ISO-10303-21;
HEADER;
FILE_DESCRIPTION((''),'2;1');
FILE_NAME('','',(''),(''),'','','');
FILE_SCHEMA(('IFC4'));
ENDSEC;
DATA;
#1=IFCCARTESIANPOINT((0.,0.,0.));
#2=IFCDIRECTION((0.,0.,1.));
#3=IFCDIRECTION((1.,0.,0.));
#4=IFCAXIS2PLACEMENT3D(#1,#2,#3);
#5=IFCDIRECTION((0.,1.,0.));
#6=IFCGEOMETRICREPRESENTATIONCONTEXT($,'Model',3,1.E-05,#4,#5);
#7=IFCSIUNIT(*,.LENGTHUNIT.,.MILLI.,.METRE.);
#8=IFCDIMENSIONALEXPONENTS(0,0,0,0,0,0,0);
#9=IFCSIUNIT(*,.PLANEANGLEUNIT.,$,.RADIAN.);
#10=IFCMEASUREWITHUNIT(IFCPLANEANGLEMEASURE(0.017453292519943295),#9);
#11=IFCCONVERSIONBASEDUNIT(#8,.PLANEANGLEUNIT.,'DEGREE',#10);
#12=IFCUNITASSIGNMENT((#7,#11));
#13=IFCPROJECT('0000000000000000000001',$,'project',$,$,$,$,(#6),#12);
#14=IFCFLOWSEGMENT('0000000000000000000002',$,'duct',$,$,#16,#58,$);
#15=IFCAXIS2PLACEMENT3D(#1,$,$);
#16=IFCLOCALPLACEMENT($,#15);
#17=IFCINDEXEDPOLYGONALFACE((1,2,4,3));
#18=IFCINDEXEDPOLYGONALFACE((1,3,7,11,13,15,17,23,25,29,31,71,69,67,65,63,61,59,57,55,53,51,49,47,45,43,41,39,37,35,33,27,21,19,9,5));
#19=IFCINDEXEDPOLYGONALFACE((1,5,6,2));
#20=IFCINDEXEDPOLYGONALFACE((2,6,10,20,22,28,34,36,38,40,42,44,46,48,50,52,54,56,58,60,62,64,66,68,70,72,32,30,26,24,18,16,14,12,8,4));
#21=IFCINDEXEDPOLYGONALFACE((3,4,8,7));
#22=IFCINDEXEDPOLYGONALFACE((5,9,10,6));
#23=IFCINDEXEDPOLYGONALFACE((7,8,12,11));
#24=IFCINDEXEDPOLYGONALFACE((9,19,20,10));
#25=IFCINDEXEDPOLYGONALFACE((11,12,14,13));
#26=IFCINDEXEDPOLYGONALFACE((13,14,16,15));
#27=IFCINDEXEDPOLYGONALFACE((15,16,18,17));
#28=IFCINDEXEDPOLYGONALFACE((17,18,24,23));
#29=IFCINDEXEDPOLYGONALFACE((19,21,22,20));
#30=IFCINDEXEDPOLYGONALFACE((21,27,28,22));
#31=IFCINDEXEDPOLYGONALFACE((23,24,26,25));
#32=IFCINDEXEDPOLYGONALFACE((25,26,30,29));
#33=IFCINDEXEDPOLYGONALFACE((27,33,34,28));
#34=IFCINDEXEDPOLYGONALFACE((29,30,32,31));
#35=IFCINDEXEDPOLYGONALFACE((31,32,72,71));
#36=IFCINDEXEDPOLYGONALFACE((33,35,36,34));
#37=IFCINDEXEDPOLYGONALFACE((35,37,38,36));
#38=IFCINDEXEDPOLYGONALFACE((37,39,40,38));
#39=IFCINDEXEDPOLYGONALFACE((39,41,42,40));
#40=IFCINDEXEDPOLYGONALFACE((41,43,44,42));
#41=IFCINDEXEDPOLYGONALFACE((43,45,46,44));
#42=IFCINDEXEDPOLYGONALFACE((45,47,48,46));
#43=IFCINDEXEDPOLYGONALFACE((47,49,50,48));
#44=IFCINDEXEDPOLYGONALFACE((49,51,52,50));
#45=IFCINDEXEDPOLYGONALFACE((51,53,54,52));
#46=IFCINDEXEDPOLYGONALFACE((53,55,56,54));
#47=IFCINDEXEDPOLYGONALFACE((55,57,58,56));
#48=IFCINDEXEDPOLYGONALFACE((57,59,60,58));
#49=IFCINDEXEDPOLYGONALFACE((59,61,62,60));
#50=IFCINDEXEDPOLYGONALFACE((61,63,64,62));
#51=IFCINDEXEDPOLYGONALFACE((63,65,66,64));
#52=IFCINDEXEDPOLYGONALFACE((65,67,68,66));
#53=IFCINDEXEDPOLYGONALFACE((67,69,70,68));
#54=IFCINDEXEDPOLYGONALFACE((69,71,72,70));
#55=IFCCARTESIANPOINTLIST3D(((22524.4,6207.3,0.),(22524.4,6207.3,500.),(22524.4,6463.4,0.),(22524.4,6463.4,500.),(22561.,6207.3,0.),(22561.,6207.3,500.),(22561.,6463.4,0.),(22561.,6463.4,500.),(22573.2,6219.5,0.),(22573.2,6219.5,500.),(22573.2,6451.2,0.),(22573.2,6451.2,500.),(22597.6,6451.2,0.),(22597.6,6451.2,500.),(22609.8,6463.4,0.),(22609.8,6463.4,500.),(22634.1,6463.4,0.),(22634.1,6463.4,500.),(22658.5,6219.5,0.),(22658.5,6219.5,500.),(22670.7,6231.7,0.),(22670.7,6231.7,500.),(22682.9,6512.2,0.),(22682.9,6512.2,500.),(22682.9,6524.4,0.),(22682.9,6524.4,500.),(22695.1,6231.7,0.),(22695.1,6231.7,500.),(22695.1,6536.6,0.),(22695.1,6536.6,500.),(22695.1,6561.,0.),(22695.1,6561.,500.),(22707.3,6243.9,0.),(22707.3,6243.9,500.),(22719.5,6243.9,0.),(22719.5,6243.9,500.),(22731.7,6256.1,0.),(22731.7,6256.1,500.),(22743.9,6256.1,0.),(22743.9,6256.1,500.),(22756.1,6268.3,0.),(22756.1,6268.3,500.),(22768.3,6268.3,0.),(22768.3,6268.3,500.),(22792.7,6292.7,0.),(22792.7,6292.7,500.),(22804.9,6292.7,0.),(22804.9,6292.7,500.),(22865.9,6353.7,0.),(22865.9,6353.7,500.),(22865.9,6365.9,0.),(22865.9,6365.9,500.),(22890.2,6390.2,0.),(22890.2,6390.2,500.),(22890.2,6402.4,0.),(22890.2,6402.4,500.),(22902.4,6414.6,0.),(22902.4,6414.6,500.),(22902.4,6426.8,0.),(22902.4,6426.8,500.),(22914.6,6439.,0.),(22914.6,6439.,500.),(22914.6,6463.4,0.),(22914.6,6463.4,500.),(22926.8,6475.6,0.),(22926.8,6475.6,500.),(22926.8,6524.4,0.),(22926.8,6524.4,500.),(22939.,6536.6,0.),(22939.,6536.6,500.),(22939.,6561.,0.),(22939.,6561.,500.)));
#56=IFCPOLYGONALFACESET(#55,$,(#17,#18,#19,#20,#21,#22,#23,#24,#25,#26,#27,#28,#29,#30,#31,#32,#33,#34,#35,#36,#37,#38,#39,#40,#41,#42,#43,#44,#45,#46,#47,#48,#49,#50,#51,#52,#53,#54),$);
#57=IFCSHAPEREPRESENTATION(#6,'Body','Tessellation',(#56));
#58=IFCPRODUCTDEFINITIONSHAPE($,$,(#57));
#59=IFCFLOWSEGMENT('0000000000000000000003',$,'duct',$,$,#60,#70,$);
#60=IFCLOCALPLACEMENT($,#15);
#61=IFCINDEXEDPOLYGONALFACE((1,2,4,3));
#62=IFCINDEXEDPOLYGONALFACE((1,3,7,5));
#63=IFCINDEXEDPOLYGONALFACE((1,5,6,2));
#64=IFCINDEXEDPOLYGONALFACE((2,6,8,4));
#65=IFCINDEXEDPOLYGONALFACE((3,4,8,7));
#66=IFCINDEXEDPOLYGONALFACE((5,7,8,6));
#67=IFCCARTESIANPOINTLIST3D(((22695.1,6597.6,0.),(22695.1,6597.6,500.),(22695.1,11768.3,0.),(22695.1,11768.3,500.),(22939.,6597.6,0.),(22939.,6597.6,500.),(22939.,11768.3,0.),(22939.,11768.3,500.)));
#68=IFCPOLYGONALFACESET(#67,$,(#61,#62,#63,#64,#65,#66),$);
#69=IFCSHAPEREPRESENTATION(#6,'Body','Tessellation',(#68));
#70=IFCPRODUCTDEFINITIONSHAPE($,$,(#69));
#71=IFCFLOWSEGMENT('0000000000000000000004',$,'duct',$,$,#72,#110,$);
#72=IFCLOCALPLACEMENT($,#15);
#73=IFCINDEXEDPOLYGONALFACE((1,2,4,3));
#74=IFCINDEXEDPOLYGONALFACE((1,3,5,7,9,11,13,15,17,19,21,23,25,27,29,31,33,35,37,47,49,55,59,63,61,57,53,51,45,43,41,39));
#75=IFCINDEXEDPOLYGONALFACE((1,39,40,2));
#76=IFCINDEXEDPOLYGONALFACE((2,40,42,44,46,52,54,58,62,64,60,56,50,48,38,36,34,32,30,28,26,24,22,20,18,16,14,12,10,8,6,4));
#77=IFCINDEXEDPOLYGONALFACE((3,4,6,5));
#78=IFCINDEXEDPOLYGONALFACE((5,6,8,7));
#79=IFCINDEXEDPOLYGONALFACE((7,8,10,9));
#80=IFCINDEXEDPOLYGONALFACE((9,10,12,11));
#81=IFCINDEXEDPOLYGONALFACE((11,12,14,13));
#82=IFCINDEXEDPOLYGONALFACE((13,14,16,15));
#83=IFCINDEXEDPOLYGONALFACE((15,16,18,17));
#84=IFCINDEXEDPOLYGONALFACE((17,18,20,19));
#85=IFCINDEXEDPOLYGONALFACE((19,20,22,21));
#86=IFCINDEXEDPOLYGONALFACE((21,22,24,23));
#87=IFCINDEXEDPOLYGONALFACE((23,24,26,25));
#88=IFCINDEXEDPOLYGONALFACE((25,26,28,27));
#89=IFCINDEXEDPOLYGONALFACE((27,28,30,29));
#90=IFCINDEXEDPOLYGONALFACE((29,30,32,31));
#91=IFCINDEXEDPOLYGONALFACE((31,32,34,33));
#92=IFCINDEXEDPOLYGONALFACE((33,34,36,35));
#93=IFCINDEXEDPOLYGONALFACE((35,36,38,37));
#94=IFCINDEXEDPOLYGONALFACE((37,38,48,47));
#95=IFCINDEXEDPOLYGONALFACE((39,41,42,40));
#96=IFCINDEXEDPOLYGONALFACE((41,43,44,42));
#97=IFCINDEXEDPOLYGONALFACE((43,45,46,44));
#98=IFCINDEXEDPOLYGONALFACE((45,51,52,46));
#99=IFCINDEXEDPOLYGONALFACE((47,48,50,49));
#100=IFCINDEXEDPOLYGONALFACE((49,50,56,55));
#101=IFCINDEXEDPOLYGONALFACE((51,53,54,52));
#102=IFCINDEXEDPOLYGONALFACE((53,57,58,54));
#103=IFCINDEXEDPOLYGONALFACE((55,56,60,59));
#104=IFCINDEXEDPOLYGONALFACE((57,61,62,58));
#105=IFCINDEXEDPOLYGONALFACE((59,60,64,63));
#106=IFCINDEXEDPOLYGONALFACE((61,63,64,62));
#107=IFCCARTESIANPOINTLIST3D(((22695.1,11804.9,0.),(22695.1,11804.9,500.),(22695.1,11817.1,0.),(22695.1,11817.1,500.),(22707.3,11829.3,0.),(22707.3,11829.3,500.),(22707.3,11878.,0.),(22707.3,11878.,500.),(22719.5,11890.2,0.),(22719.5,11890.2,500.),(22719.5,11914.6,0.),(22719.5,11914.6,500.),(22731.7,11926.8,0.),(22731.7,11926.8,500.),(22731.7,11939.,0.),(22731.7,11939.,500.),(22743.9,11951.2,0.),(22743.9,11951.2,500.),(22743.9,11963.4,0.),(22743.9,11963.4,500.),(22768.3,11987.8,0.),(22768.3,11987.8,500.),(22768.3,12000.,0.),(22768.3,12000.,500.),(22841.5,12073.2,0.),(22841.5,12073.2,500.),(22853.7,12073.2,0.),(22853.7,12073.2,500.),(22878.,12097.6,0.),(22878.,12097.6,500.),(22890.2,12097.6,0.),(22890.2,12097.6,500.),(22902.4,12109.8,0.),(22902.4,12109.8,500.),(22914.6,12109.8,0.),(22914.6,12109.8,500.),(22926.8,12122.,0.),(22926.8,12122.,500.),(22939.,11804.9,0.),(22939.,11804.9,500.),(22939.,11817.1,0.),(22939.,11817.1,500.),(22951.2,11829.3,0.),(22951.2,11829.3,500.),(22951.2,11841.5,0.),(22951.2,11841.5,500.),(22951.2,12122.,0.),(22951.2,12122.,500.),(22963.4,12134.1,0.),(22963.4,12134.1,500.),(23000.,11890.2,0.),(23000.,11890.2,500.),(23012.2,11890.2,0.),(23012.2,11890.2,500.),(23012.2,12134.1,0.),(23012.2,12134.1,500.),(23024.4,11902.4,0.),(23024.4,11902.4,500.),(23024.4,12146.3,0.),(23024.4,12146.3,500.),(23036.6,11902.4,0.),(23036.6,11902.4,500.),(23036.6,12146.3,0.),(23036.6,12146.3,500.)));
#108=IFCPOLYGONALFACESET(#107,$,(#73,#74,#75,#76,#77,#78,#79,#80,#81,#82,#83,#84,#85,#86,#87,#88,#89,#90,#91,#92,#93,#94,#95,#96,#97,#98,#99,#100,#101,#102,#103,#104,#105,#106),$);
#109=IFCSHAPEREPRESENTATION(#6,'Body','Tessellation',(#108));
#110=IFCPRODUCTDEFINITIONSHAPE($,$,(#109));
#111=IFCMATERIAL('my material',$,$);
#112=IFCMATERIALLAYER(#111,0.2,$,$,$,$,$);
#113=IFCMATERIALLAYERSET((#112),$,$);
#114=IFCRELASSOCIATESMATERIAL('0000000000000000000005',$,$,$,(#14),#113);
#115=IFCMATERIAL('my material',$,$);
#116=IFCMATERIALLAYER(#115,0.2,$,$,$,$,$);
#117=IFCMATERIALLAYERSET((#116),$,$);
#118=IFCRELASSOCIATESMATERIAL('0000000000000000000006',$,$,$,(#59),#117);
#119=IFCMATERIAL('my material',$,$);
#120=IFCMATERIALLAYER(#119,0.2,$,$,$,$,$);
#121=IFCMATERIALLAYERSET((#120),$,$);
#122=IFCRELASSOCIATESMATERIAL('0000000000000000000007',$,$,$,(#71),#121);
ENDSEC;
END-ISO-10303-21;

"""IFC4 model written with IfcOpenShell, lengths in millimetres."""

from ifc_helpers import new_model, entity, si_unit, converted_unit, direction, origin_with_axes, place, context, project, polyline, outline, extrude, material, layer, layer_set, layer_usage, element, save


model = new_model("IFC4")

# Units and contexts
model_context = context("Model", 3, precision=1e-05, world=origin_with_axes(), true_north=direction((0.0, 1.0, 0.0)))
ifc_project = project(units=[si_unit("LENGTHUNIT", "METRE", prefix="MILLI"), converted_unit("PLANEANGLEUNIT", "DEGREE", entity("IfcPlaneAngleMeasure", 0.017453292519943295), si_unit("PLANEANGLEUNIT", "RADIAN"), dimensions=[0, 0, 0, 0, 0, 0, 0])], contexts=[model_context])

# Flow segments
ifc_material_1 = material(Name="my material")
ifc_layer_1 = layer(ifc_material_1, 0.2)
ifc_layer_set_1 = layer_set([ifc_layer_1])
ifc_layer_usage_1 = layer_usage(ifc_layer_set_1, "AXIS2", "POSITIVE", -0.1)
flow_segment_1_placement = place(None, origin_with_axes())
element("IfcFlowSegment", 1, at=flow_segment_1_placement, material=ifc_layer_usage_1, Name="duct", context=model_context, shape_type="SweptSolid", body=[
    extrude(outline(polyline([(22524.4, 6207.3), (22561.0, 6207.3), (22573.2, 6219.5), (22658.5, 6219.5), (22670.7, 6231.7), (22695.1, 6231.7), (22707.3, 6243.9), (22719.5, 6243.9), (22731.7, 6256.1), (22743.9, 6256.1), (22756.1, 6268.3), (22768.3, 6268.3), (22792.7, 6292.7), (22804.9, 6292.7), (22865.9, 6353.7), (22865.9, 6365.9), (22890.2, 6390.2), (22890.2, 6402.4), (22902.4, 6414.6), (22902.4, 6426.8), (22914.6, 6439.0), (22914.6, 6463.4), (22926.8, 6475.6), (22926.8, 6524.4), (22939.0, 6536.6), (22939.0, 6561.0), (22695.1, 6561.0), (22695.1, 6536.6), (22682.9, 6524.4), (22682.9, 6512.2), (22634.1, 6463.4), (22609.8, 6463.4), (22597.6, 6451.2), (22573.2, 6451.2), (22561.0, 6463.4), (22524.4, 6463.4), (22524.4, 6207.3)])), origin_with_axes(), (0.0, 0.0, 1.0), 500.0),
])
ifc_material_2 = material(Name="my material")
ifc_layer_2 = layer(ifc_material_2, 0.2)
ifc_layer_set_2 = layer_set([ifc_layer_2])
ifc_layer_usage_2 = layer_usage(ifc_layer_set_2, "AXIS2", "POSITIVE", -0.1)
flow_segment_2_placement = place(None, origin_with_axes())
element("IfcFlowSegment", 2, at=flow_segment_2_placement, material=ifc_layer_usage_2, Name="duct", context=model_context, shape_type="SweptSolid", body=[
    extrude(outline(polyline([(22695.1, 6597.6), (22939.0, 6597.6), (22939.0, 11768.3), (22695.1, 11768.3), (22695.1, 6597.6)])), origin_with_axes(), (0.0, 0.0, 1.0), 500.0),
])
ifc_material_3 = material(Name="my material")
ifc_layer_3 = layer(ifc_material_3, 0.2)
ifc_layer_set_3 = layer_set([ifc_layer_3])
ifc_layer_usage_3 = layer_usage(ifc_layer_set_3, "AXIS2", "POSITIVE", -0.1)
flow_segment_3_placement = place(None, origin_with_axes())
element("IfcFlowSegment", 3, at=flow_segment_3_placement, material=ifc_layer_usage_3, Name="duct", context=model_context, shape_type="SweptSolid", body=[
    extrude(outline(polyline([(22695.1, 11804.9), (22939.0, 11804.9), (22939.0, 11817.1), (22951.2, 11829.3), (22951.2, 11841.5), (23000.0, 11890.2), (23012.2, 11890.2), (23024.4, 11902.4), (23036.6, 11902.4), (23036.6, 12146.3), (23024.4, 12146.3), (23012.2, 12134.1), (22963.4, 12134.1), (22951.2, 12122.0), (22926.8, 12122.0), (22914.6, 12109.8), (22902.4, 12109.8), (22890.2, 12097.6), (22878.0, 12097.6), (22853.7, 12073.2), (22841.5, 12073.2), (22768.3, 12000.0), (22768.3, 11987.8), (22743.9, 11963.4), (22743.9, 11951.2), (22731.7, 11939.0), (22731.7, 11926.8), (22719.5, 11914.6), (22719.5, 11890.2), (22707.3, 11878.0), (22707.3, 11829.3), (22695.1, 11817.1), (22695.1, 11804.9)])), origin_with_axes(), (0.0, 0.0, 1.0), 500.0),
])

save(model, "model.ifc")
